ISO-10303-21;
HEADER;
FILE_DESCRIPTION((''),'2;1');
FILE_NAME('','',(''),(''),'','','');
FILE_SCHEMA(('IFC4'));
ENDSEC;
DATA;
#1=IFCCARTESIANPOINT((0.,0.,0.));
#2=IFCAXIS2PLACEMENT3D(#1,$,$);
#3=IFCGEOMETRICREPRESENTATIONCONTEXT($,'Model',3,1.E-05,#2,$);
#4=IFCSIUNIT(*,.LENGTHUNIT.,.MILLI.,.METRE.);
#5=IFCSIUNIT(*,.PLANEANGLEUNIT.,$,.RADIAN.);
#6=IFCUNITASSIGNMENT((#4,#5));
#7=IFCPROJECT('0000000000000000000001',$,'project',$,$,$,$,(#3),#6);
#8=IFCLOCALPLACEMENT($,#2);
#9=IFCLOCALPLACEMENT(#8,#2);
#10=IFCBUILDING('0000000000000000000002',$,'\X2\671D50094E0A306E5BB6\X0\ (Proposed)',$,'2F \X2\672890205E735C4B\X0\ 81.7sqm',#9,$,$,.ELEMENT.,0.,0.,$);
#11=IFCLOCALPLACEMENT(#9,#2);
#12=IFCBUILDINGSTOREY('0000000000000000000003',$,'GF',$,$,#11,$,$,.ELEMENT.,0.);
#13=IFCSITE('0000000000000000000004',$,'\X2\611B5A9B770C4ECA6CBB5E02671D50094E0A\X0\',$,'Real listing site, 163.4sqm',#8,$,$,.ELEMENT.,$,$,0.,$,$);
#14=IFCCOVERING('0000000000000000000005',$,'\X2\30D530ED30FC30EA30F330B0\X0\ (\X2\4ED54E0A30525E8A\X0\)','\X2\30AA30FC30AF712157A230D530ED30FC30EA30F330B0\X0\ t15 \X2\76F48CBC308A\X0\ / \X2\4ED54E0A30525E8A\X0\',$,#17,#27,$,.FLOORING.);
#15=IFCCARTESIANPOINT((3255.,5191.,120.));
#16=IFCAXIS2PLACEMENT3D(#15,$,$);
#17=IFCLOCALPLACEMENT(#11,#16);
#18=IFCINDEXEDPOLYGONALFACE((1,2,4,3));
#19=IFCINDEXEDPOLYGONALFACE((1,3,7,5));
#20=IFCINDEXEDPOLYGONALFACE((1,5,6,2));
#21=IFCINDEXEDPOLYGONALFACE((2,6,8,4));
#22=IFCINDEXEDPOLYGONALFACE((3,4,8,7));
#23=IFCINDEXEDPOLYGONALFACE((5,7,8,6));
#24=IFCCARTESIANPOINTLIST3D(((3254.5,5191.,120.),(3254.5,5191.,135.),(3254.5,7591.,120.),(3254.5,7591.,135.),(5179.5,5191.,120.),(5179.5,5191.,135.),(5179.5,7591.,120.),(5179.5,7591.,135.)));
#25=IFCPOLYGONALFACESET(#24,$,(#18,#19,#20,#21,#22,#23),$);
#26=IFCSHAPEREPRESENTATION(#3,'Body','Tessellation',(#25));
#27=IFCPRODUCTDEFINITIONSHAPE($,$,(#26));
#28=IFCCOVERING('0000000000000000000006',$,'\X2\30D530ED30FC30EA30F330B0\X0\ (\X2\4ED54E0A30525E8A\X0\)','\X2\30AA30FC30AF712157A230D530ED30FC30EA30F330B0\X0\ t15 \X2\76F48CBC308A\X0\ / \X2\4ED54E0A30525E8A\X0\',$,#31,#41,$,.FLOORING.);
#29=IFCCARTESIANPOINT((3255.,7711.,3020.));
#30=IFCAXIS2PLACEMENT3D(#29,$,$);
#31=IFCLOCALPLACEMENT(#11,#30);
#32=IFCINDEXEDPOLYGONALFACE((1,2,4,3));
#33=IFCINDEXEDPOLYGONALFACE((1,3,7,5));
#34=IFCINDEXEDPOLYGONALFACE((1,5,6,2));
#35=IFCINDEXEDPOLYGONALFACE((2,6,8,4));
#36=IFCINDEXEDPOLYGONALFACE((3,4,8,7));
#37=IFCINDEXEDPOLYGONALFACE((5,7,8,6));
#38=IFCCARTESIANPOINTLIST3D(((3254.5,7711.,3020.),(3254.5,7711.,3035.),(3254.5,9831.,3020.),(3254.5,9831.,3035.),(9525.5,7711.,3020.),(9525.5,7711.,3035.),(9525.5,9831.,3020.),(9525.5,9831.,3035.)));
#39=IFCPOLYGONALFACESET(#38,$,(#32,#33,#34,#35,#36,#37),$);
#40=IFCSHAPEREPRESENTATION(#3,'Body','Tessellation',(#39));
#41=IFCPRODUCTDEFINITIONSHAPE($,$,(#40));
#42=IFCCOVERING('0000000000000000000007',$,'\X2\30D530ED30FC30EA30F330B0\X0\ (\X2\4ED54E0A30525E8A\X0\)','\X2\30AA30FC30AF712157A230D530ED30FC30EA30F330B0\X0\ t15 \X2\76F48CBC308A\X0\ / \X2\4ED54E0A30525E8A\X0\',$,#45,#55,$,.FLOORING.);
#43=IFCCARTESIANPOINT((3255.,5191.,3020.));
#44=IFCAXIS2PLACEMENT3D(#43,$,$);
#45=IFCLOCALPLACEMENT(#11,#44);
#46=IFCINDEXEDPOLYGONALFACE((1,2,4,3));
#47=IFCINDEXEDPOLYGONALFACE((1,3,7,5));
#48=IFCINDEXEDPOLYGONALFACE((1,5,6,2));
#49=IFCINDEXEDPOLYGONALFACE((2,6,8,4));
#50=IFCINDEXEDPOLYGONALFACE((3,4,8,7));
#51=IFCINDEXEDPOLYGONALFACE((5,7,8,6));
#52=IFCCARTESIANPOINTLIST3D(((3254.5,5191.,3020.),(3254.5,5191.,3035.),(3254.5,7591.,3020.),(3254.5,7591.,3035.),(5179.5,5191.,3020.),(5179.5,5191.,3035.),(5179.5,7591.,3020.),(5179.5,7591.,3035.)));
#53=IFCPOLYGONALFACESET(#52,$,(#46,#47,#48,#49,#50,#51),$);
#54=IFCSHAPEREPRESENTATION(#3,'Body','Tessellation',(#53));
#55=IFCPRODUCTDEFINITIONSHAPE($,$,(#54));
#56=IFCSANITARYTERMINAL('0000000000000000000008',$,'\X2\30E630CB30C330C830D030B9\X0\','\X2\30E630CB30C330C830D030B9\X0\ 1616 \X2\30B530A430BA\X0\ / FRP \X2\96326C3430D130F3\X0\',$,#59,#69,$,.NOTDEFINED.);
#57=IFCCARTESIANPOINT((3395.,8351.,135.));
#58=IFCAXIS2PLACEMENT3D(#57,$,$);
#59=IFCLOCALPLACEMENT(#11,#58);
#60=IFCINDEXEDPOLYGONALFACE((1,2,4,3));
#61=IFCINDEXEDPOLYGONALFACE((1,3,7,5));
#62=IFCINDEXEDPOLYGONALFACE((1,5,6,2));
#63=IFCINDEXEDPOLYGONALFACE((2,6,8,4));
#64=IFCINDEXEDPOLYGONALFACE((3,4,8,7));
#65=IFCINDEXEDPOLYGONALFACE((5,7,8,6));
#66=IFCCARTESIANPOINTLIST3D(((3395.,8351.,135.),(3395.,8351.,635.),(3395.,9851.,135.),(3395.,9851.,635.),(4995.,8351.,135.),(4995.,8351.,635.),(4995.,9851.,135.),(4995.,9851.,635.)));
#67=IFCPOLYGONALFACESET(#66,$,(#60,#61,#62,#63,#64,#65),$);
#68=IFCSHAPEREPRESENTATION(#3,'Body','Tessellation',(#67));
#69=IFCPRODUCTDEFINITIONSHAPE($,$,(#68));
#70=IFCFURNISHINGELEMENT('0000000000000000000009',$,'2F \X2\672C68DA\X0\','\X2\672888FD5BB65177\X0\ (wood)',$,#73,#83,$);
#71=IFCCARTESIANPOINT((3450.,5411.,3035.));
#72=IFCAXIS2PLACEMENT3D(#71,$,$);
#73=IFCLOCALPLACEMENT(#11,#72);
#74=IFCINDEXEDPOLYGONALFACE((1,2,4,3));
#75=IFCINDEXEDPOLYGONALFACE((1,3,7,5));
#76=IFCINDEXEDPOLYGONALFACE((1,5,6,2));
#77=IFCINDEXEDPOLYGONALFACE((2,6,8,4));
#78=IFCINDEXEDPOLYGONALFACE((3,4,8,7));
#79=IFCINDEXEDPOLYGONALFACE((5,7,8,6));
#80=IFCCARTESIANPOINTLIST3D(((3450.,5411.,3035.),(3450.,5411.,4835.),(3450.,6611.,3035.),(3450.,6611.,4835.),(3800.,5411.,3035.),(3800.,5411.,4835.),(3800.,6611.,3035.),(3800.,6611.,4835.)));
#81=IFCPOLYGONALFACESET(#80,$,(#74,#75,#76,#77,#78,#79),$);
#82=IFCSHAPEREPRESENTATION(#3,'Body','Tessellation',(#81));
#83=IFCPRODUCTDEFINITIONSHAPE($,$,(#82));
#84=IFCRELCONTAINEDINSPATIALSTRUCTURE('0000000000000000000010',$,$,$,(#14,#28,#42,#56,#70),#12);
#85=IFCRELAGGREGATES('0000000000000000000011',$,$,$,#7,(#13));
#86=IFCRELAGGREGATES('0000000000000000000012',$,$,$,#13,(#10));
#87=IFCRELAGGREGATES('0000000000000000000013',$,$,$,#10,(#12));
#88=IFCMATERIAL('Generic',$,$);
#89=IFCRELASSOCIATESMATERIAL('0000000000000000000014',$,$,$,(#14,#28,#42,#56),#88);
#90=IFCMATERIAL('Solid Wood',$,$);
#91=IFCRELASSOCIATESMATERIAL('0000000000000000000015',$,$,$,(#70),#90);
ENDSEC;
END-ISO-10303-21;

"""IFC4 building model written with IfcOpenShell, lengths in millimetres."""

from ifc_helpers import new_model, si_unit, frame, frame_2d, origin, place, context, project, spatial, rectangle, extrude, material, element, save


model = new_model("IFC4")

# Units and contexts
model_context = context("Model", 3, precision=1e-05, world=origin())
ifc_project = project(units=[si_unit("LENGTHUNIT", "METRE", prefix="MILLI"), si_unit("PLANEANGLEUNIT", "RADIAN")], contexts=[model_context])

# Site, building, storey
site_placement = place(None, origin())
site = spatial("IfcSite", under=ifc_project, at=site_placement, Name="愛媛県今治市朝倉上", ObjectType="Real listing site, 163.4sqm", CompositionType="ELEMENT", RefElevation=0.0)
building_placement = place(site_placement, origin())
building = spatial("IfcBuilding", under=site, at=building_placement, Name="朝倉上の家 (Proposed)", ObjectType="2F 木造平屋 81.7sqm", CompositionType="ELEMENT", ElevationOfRefHeight=0.0, ElevationOfTerrain=0.0)
storey_placement = place(building_placement, origin())
storey = spatial("IfcBuildingStorey", under=building, at=storey_placement, Name="GF", CompositionType="ELEMENT", Elevation=0.0)

# Shared definitions
ifc_material_1 = material(Name="Solid Wood")

# Coverings
ifc_material_2 = material(Name="Generic")
covering_1_placement = place(storey_placement, frame((3255.0, 5191.0, 120.0)))
element("IfcCovering", 1, at=covering_1_placement, inside=storey, material=ifc_material_2, Name="フローリング (仕上げ床)", Description="オーク無垢フローリング t15 直貼り / 仕上げ床", PredefinedType="FLOORING", context=model_context, shape_type="SweptSolid", body=[
    extrude(rectangle(XDim=1925.0, YDim=2400.0, at=frame_2d((962.0, 1200.0))), frame((3255.0, 5191.0, 120.0)), (0.0, 0.0, 1.0), 15.0),
])
covering_2_placement = place(storey_placement, frame((3255.0, 7711.0, 3020.0)))
element("IfcCovering", 2, at=covering_2_placement, inside=storey, material=ifc_material_2, Name="フローリング (仕上げ床)", Description="オーク無垢フローリング t15 直貼り / 仕上げ床", PredefinedType="FLOORING", context=model_context, shape_type="SweptSolid", body=[
    extrude(rectangle(XDim=6271.0, YDim=2120.0, at=frame_2d((3135.0, 1060.0))), frame((3255.0, 7711.0, 3020.0)), (0.0, 0.0, 1.0), 15.0),
])
covering_3_placement = place(storey_placement, frame((3255.0, 5191.0, 3020.0)))
element("IfcCovering", 3, at=covering_3_placement, inside=storey, material=ifc_material_2, Name="フローリング (仕上げ床)", Description="オーク無垢フローリング t15 直貼り / 仕上げ床", PredefinedType="FLOORING", context=model_context, shape_type="SweptSolid", body=[
    extrude(rectangle(XDim=1925.0, YDim=2400.0, at=frame_2d((962.0, 1200.0))), frame((3255.0, 5191.0, 3020.0)), (0.0, 0.0, 1.0), 15.0),
])

# Sanitary terminal
sanitary_terminal_placement = place(storey_placement, frame((3395.0, 8351.0, 135.0)))
element("IfcSanitaryTerminal", 4, at=sanitary_terminal_placement, inside=storey, material=ifc_material_2, Name="ユニットバス", Description="ユニットバス 1616 サイズ / FRP 防水パン", PredefinedType="NOTDEFINED", context=model_context, shape_type="SweptSolid", body=[
    extrude(rectangle(XDim=1600.0, YDim=1500.0, at=frame_2d((800.0, 750.0))), frame((3395.0, 8351.0, 135.0)), (0.0, 0.0, 1.0), 500.0),
])

# Furnishing element
furnishing_placement = place(storey_placement, frame((3450.0, 5411.0, 3035.0)))
element("IfcFurnishingElement", 5, at=furnishing_placement, inside=storey, material=ifc_material_1, Name="2F 本棚", Description="木製家具 (wood)", context=model_context, shape_type="SweptSolid", body=[
    extrude(rectangle(XDim=350.0, YDim=1200.0, at=frame_2d((175.0, 600.0))), frame((3450.0, 5411.0, 3035.0)), (0.0, 0.0, 1.0), 1800.0),
])

save(model, "model.ifc")
